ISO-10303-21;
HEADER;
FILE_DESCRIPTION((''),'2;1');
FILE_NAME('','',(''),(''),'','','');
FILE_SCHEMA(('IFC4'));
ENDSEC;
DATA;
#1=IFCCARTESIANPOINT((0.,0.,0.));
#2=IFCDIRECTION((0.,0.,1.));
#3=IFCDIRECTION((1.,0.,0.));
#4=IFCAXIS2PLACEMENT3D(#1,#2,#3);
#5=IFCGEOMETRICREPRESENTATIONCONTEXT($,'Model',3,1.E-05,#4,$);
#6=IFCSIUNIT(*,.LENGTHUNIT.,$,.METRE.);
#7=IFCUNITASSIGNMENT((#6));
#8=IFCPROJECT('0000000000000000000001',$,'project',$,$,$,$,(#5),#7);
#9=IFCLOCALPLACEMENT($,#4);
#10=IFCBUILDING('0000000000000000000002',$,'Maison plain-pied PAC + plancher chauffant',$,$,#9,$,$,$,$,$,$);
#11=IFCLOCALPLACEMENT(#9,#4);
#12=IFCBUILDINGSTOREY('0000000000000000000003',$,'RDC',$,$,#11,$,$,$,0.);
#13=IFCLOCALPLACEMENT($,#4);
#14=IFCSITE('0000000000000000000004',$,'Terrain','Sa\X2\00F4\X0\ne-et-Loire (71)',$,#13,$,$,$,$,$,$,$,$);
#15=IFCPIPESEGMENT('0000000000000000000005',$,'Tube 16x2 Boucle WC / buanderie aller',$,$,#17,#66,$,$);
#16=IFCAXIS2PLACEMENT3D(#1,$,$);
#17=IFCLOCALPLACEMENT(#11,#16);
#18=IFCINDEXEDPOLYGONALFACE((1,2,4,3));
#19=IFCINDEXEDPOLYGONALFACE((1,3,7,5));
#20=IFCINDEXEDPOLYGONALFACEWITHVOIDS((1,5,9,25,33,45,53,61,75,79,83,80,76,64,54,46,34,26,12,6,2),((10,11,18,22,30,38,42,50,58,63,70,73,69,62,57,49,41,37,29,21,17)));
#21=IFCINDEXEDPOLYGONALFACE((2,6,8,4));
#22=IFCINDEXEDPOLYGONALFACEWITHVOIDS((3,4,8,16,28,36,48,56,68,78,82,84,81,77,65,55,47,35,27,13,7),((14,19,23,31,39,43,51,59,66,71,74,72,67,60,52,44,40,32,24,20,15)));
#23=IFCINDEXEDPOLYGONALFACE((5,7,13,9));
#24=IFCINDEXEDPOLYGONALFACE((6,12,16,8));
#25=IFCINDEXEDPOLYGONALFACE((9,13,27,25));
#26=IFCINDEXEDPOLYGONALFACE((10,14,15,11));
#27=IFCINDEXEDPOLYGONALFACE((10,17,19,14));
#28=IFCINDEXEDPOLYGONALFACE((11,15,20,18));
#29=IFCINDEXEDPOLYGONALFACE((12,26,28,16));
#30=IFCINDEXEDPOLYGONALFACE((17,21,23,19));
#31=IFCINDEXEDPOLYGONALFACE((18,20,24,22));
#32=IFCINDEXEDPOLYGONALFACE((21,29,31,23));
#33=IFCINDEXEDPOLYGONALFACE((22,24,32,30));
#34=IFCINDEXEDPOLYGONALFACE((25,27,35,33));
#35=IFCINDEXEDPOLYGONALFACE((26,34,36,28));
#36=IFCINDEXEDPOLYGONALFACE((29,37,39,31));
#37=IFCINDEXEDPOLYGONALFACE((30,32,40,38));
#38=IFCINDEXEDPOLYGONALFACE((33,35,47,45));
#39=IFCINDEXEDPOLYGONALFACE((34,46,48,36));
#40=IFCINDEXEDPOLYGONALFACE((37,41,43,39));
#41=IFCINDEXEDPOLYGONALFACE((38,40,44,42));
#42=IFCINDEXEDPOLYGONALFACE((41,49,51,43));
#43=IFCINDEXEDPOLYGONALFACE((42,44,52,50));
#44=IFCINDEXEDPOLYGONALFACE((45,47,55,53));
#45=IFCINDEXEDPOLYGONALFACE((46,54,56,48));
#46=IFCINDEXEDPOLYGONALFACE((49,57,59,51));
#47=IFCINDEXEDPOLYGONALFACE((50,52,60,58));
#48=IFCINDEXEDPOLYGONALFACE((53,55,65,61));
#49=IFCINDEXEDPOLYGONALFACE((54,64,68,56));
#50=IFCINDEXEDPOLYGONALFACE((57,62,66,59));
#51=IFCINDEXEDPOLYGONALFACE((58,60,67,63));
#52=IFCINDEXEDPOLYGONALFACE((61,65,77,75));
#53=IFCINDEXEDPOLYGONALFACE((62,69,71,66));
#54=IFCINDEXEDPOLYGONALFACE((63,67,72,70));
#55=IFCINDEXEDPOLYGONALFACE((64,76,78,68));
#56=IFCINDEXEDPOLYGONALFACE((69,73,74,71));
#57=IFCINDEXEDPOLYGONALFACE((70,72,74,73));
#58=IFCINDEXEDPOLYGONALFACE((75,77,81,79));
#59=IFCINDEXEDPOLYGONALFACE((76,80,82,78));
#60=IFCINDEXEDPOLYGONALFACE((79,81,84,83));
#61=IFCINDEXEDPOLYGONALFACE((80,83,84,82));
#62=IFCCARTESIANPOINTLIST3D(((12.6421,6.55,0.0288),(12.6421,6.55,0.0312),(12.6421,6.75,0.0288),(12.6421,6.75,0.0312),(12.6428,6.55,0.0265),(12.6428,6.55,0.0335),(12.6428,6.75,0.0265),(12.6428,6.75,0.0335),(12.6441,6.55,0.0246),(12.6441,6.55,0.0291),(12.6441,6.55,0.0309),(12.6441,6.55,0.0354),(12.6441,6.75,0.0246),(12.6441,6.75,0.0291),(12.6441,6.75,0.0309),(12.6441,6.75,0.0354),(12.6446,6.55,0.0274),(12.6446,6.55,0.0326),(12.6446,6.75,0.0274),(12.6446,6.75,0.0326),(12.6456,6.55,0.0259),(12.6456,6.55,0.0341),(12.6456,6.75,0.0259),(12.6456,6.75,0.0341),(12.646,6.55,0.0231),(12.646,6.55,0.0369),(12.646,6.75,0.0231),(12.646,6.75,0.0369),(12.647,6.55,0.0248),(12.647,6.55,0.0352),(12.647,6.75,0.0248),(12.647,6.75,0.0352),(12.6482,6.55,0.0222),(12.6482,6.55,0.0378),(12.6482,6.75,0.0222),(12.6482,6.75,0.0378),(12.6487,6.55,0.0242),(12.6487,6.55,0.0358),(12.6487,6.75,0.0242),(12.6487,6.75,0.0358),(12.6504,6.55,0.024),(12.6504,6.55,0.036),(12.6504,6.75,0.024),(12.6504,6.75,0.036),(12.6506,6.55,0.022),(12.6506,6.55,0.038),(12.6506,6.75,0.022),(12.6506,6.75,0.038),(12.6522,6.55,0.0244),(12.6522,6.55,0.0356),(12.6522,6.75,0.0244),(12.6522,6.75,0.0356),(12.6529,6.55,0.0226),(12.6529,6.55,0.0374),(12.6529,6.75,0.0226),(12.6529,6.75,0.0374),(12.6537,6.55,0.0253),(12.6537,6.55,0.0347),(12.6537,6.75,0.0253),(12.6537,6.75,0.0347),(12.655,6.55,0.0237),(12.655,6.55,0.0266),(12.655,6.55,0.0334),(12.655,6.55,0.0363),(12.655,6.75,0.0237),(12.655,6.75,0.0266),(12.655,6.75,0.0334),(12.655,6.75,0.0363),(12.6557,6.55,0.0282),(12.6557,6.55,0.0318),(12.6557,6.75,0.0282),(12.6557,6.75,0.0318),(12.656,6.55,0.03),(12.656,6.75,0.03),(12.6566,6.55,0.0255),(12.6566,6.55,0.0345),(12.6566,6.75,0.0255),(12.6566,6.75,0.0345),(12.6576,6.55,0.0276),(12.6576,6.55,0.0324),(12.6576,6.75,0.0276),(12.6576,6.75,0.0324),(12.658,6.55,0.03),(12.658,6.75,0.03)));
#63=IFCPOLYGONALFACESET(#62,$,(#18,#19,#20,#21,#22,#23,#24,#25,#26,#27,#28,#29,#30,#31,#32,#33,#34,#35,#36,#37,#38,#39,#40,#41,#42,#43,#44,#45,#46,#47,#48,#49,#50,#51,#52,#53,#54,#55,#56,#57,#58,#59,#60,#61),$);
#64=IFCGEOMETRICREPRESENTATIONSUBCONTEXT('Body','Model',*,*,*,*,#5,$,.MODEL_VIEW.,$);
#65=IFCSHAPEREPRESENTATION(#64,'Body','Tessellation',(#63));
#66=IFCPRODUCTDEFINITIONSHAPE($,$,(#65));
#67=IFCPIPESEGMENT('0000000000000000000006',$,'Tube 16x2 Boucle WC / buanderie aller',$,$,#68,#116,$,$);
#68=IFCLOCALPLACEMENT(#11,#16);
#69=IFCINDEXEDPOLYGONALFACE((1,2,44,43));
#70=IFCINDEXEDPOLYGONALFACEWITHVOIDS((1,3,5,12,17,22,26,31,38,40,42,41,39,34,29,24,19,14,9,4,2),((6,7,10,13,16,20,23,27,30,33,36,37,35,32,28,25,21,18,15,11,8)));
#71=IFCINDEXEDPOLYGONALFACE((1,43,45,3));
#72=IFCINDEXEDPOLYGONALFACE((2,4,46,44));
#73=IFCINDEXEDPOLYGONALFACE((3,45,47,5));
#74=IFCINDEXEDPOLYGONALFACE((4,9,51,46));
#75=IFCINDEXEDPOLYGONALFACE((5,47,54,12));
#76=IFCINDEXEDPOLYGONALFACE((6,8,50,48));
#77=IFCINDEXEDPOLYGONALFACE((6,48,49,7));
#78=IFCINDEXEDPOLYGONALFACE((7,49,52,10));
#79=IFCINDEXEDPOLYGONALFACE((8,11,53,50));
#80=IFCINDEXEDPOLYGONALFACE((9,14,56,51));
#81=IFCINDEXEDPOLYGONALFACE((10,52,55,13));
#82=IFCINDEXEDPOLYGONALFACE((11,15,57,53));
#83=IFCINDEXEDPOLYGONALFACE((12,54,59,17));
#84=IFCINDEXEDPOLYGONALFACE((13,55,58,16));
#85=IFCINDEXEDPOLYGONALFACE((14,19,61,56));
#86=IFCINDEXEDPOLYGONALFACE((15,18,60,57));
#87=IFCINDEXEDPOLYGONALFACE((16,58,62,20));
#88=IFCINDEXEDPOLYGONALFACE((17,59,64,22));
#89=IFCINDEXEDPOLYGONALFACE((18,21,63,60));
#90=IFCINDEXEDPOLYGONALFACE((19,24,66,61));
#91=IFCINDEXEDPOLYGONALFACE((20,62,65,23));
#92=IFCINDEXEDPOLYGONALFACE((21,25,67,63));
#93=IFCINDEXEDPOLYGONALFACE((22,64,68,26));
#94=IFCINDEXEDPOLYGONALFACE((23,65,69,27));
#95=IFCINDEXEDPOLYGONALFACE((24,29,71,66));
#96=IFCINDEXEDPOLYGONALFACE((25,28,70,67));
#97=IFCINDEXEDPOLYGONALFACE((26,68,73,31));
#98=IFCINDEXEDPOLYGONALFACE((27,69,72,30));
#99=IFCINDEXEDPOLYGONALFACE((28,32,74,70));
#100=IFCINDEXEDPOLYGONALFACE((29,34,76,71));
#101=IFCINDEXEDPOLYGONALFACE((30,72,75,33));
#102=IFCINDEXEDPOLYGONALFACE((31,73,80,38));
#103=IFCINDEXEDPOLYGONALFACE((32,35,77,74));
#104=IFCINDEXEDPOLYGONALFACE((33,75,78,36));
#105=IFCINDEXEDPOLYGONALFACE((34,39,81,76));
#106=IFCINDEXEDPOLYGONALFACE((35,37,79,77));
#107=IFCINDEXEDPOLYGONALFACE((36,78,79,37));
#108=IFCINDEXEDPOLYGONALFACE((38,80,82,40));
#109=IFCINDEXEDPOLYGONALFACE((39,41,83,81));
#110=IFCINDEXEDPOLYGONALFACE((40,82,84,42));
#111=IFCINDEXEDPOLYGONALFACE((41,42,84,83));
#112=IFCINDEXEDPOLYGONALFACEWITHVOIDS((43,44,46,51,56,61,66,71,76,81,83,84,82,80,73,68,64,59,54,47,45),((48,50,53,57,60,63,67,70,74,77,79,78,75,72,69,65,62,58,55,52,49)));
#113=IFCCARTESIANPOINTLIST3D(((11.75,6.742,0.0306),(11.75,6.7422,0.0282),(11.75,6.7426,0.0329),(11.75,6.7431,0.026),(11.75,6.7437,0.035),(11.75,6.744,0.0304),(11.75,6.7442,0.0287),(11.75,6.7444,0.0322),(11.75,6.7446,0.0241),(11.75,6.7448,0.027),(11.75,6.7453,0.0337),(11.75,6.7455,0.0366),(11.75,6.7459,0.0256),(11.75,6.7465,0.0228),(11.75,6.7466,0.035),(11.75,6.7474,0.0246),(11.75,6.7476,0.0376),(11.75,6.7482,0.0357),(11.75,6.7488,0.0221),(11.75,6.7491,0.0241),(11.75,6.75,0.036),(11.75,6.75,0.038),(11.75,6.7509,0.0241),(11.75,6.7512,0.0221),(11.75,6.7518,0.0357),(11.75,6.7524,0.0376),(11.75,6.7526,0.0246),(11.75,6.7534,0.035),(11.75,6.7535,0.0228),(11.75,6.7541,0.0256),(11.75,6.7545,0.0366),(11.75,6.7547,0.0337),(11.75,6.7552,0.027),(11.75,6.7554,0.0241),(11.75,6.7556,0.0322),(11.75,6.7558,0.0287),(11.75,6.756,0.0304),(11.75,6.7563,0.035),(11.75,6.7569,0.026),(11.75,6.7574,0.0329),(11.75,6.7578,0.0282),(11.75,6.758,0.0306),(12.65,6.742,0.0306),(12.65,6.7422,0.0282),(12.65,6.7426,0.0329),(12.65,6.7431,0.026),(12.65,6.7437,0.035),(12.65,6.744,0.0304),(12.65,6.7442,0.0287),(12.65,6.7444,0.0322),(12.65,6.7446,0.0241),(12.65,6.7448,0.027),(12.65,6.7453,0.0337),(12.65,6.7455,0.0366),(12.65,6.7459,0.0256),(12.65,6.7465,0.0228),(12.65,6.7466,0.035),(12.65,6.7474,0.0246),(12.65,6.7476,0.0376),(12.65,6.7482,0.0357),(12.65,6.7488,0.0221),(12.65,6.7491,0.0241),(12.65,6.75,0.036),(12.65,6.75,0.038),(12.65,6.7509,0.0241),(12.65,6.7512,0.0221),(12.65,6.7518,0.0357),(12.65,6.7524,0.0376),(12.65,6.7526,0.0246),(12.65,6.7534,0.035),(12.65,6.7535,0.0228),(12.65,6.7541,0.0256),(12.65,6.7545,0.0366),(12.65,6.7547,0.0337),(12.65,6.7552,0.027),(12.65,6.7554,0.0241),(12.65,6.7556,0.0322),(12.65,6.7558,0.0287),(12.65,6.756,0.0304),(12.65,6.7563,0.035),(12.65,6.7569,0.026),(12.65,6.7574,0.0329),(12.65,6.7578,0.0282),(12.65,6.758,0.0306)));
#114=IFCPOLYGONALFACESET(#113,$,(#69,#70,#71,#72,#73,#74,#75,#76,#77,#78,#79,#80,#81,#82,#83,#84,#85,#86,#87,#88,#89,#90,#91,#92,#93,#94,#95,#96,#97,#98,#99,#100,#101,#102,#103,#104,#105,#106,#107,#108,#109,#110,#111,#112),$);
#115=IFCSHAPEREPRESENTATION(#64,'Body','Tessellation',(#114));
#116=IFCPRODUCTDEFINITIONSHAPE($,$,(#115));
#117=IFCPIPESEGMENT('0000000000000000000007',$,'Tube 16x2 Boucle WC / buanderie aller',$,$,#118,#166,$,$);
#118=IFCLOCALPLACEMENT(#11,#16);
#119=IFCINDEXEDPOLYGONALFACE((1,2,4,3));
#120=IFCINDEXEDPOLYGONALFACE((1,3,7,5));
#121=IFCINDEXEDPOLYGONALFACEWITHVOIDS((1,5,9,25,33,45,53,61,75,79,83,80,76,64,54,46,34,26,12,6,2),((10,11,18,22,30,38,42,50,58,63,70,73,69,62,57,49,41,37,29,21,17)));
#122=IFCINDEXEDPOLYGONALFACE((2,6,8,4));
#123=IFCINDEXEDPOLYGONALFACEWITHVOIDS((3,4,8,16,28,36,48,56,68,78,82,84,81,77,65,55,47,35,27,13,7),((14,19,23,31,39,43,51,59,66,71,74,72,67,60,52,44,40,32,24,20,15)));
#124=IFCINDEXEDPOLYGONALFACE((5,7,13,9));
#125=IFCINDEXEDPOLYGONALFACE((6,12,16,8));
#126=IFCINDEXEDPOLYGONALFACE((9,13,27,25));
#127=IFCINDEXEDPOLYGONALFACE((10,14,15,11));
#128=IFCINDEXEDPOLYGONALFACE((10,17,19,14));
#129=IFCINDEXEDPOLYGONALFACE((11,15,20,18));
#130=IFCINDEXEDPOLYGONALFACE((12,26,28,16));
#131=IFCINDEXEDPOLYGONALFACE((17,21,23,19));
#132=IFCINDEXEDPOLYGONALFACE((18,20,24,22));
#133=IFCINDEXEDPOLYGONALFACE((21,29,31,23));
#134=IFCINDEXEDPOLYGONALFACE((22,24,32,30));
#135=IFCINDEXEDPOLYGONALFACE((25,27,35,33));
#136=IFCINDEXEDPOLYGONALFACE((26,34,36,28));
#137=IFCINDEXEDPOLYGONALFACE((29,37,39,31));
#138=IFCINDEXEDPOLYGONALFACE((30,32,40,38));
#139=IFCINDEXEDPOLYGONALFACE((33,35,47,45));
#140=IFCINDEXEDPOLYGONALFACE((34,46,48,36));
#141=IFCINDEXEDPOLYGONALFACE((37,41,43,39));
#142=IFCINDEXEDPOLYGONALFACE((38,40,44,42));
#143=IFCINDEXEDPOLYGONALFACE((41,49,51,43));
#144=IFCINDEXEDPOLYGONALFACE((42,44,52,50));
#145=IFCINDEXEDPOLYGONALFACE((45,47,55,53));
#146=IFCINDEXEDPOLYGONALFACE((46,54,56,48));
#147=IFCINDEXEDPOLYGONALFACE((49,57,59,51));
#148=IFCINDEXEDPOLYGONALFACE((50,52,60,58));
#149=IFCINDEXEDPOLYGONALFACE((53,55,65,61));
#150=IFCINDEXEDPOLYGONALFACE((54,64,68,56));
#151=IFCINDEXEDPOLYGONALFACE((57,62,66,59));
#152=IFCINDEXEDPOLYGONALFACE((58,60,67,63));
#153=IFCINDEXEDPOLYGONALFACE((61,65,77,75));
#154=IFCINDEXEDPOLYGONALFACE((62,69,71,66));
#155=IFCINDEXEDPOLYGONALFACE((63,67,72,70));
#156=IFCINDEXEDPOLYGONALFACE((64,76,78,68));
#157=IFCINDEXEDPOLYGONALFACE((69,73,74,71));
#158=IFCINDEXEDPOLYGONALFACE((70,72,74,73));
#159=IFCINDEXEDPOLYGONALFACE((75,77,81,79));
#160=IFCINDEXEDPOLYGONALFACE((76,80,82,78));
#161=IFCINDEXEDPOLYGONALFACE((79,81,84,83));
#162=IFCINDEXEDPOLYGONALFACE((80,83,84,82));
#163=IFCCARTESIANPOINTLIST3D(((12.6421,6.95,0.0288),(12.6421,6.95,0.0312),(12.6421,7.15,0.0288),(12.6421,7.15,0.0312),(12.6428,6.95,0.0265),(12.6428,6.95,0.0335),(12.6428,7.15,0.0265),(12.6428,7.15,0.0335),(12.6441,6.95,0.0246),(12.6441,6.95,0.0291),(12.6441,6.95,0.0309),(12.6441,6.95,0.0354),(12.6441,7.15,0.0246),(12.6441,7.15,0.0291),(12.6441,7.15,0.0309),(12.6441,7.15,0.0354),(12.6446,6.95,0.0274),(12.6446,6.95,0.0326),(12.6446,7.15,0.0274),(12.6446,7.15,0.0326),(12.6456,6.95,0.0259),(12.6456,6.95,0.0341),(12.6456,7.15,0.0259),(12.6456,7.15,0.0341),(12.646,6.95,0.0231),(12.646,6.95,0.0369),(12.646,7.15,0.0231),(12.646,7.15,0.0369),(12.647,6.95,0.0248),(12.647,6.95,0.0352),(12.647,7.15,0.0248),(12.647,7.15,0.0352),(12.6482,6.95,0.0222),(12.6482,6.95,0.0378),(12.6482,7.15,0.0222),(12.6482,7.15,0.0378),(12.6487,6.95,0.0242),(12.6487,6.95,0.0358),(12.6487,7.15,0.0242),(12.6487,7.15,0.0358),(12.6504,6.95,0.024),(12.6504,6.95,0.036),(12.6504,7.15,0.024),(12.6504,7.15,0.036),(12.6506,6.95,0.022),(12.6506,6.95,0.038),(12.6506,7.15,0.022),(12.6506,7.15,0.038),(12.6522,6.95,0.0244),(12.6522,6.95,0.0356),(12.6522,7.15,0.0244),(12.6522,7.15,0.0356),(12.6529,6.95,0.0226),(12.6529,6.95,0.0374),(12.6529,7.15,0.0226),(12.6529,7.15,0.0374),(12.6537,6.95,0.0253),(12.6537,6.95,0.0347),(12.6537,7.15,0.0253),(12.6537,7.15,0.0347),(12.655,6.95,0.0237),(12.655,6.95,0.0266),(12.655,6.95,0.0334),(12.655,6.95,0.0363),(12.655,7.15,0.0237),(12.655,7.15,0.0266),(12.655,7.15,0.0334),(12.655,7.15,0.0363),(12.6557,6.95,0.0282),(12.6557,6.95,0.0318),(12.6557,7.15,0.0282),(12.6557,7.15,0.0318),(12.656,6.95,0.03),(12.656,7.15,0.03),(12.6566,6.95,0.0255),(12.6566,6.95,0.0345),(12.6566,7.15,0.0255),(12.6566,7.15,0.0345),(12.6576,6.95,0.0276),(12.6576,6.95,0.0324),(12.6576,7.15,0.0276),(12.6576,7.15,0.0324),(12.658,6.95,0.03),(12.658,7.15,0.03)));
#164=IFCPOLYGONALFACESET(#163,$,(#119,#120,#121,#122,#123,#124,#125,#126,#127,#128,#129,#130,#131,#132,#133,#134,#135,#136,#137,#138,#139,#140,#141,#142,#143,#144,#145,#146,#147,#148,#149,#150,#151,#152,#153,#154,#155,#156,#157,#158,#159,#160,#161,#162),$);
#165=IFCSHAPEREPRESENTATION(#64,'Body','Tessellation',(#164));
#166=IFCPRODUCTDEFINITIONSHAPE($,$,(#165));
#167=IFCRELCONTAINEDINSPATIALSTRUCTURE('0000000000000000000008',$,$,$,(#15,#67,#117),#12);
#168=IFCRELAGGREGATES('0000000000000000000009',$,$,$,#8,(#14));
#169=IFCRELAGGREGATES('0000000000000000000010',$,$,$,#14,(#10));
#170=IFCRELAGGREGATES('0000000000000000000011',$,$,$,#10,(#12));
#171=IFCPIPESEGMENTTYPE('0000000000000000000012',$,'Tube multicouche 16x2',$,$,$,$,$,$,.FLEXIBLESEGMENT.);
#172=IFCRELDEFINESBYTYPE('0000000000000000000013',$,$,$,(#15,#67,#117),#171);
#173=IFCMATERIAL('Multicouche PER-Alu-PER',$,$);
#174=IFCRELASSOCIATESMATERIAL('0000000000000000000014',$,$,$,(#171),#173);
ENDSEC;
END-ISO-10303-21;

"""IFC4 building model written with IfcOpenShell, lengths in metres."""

from ifc_helpers import new_model, si_unit, frame, origin_with_axes, place, context, subcontext, project, spatial, hollow_circle, extrude, material, type_object, element, save


model = new_model("IFC4")

# Units and contexts
model_context = context("Model", 3, precision=1e-05, world=origin_with_axes())
body_context = subcontext(model_context, "Body", "Model", "MODEL_VIEW")
ifc_project = project(units=[si_unit("LENGTHUNIT", "METRE")], contexts=[model_context])

# Site, building, storey
site_placement = place(None, origin_with_axes())
site = spatial("IfcSite", under=ifc_project, at=site_placement, Name="Terrain", Description="Saône-et-Loire (71)")
building_placement = place(None, origin_with_axes())
building = spatial("IfcBuilding", under=site, at=building_placement, Name="Maison plain-pied PAC + plancher chauffant")
storey_placement = place(building_placement, origin_with_axes())
storey = spatial("IfcBuildingStorey", under=building, at=storey_placement, Name="RDC", Elevation=0.0)

# Pipe segments
ifc_material_1 = material(Name="Multicouche PER-Alu-PER")
pipe_segment_type_1 = type_object("IfcPipeSegmentType", Name="Tube multicouche 16x2", PredefinedType="FLEXIBLESEGMENT", material=ifc_material_1)
pipe_segment_1_placement = place(storey_placement, frame((12.65, 6.55, 0.03), z_axis=(0.0, 1.0, 0.0), x_axis=(1.0, 0.0, 0.0)))
element("IfcPipeSegment", 1, at=pipe_segment_1_placement, inside=storey, type_object=pipe_segment_type_1, Name="Tube 16x2 Boucle WC / buanderie aller", context=body_context, shape_type="SweptSolid", body=[
    extrude(hollow_circle(Radius=0.008, WallThickness=0.002), origin_with_axes(), (0.0, 0.0, 1.0), 0.2),
])
pipe_segment_2_placement = place(storey_placement, frame((12.65, 6.75, 0.03), z_axis=(-1.0, 0.0, 0.0), x_axis=(0.0, 0.0, 1.0)))
element("IfcPipeSegment", 2, at=pipe_segment_2_placement, inside=storey, type_object=pipe_segment_type_1, Name="Tube 16x2 Boucle WC / buanderie aller", context=body_context, shape_type="SweptSolid", body=[
    extrude(hollow_circle(Radius=0.008, WallThickness=0.002), origin_with_axes(), (0.0, 0.0, 1.0), 0.9),
])
pipe_segment_3_placement = place(storey_placement, frame((12.65, 6.95, 0.03), z_axis=(0.0, 1.0, 0.0), x_axis=(1.0, 0.0, 0.0)))
element("IfcPipeSegment", 3, at=pipe_segment_3_placement, inside=storey, type_object=pipe_segment_type_1, Name="Tube 16x2 Boucle WC / buanderie aller", context=body_context, shape_type="SweptSolid", body=[
    extrude(hollow_circle(Radius=0.008, WallThickness=0.002), origin_with_axes(), (0.0, 0.0, 1.0), 0.2),
])

save(model, "model.ifc")
